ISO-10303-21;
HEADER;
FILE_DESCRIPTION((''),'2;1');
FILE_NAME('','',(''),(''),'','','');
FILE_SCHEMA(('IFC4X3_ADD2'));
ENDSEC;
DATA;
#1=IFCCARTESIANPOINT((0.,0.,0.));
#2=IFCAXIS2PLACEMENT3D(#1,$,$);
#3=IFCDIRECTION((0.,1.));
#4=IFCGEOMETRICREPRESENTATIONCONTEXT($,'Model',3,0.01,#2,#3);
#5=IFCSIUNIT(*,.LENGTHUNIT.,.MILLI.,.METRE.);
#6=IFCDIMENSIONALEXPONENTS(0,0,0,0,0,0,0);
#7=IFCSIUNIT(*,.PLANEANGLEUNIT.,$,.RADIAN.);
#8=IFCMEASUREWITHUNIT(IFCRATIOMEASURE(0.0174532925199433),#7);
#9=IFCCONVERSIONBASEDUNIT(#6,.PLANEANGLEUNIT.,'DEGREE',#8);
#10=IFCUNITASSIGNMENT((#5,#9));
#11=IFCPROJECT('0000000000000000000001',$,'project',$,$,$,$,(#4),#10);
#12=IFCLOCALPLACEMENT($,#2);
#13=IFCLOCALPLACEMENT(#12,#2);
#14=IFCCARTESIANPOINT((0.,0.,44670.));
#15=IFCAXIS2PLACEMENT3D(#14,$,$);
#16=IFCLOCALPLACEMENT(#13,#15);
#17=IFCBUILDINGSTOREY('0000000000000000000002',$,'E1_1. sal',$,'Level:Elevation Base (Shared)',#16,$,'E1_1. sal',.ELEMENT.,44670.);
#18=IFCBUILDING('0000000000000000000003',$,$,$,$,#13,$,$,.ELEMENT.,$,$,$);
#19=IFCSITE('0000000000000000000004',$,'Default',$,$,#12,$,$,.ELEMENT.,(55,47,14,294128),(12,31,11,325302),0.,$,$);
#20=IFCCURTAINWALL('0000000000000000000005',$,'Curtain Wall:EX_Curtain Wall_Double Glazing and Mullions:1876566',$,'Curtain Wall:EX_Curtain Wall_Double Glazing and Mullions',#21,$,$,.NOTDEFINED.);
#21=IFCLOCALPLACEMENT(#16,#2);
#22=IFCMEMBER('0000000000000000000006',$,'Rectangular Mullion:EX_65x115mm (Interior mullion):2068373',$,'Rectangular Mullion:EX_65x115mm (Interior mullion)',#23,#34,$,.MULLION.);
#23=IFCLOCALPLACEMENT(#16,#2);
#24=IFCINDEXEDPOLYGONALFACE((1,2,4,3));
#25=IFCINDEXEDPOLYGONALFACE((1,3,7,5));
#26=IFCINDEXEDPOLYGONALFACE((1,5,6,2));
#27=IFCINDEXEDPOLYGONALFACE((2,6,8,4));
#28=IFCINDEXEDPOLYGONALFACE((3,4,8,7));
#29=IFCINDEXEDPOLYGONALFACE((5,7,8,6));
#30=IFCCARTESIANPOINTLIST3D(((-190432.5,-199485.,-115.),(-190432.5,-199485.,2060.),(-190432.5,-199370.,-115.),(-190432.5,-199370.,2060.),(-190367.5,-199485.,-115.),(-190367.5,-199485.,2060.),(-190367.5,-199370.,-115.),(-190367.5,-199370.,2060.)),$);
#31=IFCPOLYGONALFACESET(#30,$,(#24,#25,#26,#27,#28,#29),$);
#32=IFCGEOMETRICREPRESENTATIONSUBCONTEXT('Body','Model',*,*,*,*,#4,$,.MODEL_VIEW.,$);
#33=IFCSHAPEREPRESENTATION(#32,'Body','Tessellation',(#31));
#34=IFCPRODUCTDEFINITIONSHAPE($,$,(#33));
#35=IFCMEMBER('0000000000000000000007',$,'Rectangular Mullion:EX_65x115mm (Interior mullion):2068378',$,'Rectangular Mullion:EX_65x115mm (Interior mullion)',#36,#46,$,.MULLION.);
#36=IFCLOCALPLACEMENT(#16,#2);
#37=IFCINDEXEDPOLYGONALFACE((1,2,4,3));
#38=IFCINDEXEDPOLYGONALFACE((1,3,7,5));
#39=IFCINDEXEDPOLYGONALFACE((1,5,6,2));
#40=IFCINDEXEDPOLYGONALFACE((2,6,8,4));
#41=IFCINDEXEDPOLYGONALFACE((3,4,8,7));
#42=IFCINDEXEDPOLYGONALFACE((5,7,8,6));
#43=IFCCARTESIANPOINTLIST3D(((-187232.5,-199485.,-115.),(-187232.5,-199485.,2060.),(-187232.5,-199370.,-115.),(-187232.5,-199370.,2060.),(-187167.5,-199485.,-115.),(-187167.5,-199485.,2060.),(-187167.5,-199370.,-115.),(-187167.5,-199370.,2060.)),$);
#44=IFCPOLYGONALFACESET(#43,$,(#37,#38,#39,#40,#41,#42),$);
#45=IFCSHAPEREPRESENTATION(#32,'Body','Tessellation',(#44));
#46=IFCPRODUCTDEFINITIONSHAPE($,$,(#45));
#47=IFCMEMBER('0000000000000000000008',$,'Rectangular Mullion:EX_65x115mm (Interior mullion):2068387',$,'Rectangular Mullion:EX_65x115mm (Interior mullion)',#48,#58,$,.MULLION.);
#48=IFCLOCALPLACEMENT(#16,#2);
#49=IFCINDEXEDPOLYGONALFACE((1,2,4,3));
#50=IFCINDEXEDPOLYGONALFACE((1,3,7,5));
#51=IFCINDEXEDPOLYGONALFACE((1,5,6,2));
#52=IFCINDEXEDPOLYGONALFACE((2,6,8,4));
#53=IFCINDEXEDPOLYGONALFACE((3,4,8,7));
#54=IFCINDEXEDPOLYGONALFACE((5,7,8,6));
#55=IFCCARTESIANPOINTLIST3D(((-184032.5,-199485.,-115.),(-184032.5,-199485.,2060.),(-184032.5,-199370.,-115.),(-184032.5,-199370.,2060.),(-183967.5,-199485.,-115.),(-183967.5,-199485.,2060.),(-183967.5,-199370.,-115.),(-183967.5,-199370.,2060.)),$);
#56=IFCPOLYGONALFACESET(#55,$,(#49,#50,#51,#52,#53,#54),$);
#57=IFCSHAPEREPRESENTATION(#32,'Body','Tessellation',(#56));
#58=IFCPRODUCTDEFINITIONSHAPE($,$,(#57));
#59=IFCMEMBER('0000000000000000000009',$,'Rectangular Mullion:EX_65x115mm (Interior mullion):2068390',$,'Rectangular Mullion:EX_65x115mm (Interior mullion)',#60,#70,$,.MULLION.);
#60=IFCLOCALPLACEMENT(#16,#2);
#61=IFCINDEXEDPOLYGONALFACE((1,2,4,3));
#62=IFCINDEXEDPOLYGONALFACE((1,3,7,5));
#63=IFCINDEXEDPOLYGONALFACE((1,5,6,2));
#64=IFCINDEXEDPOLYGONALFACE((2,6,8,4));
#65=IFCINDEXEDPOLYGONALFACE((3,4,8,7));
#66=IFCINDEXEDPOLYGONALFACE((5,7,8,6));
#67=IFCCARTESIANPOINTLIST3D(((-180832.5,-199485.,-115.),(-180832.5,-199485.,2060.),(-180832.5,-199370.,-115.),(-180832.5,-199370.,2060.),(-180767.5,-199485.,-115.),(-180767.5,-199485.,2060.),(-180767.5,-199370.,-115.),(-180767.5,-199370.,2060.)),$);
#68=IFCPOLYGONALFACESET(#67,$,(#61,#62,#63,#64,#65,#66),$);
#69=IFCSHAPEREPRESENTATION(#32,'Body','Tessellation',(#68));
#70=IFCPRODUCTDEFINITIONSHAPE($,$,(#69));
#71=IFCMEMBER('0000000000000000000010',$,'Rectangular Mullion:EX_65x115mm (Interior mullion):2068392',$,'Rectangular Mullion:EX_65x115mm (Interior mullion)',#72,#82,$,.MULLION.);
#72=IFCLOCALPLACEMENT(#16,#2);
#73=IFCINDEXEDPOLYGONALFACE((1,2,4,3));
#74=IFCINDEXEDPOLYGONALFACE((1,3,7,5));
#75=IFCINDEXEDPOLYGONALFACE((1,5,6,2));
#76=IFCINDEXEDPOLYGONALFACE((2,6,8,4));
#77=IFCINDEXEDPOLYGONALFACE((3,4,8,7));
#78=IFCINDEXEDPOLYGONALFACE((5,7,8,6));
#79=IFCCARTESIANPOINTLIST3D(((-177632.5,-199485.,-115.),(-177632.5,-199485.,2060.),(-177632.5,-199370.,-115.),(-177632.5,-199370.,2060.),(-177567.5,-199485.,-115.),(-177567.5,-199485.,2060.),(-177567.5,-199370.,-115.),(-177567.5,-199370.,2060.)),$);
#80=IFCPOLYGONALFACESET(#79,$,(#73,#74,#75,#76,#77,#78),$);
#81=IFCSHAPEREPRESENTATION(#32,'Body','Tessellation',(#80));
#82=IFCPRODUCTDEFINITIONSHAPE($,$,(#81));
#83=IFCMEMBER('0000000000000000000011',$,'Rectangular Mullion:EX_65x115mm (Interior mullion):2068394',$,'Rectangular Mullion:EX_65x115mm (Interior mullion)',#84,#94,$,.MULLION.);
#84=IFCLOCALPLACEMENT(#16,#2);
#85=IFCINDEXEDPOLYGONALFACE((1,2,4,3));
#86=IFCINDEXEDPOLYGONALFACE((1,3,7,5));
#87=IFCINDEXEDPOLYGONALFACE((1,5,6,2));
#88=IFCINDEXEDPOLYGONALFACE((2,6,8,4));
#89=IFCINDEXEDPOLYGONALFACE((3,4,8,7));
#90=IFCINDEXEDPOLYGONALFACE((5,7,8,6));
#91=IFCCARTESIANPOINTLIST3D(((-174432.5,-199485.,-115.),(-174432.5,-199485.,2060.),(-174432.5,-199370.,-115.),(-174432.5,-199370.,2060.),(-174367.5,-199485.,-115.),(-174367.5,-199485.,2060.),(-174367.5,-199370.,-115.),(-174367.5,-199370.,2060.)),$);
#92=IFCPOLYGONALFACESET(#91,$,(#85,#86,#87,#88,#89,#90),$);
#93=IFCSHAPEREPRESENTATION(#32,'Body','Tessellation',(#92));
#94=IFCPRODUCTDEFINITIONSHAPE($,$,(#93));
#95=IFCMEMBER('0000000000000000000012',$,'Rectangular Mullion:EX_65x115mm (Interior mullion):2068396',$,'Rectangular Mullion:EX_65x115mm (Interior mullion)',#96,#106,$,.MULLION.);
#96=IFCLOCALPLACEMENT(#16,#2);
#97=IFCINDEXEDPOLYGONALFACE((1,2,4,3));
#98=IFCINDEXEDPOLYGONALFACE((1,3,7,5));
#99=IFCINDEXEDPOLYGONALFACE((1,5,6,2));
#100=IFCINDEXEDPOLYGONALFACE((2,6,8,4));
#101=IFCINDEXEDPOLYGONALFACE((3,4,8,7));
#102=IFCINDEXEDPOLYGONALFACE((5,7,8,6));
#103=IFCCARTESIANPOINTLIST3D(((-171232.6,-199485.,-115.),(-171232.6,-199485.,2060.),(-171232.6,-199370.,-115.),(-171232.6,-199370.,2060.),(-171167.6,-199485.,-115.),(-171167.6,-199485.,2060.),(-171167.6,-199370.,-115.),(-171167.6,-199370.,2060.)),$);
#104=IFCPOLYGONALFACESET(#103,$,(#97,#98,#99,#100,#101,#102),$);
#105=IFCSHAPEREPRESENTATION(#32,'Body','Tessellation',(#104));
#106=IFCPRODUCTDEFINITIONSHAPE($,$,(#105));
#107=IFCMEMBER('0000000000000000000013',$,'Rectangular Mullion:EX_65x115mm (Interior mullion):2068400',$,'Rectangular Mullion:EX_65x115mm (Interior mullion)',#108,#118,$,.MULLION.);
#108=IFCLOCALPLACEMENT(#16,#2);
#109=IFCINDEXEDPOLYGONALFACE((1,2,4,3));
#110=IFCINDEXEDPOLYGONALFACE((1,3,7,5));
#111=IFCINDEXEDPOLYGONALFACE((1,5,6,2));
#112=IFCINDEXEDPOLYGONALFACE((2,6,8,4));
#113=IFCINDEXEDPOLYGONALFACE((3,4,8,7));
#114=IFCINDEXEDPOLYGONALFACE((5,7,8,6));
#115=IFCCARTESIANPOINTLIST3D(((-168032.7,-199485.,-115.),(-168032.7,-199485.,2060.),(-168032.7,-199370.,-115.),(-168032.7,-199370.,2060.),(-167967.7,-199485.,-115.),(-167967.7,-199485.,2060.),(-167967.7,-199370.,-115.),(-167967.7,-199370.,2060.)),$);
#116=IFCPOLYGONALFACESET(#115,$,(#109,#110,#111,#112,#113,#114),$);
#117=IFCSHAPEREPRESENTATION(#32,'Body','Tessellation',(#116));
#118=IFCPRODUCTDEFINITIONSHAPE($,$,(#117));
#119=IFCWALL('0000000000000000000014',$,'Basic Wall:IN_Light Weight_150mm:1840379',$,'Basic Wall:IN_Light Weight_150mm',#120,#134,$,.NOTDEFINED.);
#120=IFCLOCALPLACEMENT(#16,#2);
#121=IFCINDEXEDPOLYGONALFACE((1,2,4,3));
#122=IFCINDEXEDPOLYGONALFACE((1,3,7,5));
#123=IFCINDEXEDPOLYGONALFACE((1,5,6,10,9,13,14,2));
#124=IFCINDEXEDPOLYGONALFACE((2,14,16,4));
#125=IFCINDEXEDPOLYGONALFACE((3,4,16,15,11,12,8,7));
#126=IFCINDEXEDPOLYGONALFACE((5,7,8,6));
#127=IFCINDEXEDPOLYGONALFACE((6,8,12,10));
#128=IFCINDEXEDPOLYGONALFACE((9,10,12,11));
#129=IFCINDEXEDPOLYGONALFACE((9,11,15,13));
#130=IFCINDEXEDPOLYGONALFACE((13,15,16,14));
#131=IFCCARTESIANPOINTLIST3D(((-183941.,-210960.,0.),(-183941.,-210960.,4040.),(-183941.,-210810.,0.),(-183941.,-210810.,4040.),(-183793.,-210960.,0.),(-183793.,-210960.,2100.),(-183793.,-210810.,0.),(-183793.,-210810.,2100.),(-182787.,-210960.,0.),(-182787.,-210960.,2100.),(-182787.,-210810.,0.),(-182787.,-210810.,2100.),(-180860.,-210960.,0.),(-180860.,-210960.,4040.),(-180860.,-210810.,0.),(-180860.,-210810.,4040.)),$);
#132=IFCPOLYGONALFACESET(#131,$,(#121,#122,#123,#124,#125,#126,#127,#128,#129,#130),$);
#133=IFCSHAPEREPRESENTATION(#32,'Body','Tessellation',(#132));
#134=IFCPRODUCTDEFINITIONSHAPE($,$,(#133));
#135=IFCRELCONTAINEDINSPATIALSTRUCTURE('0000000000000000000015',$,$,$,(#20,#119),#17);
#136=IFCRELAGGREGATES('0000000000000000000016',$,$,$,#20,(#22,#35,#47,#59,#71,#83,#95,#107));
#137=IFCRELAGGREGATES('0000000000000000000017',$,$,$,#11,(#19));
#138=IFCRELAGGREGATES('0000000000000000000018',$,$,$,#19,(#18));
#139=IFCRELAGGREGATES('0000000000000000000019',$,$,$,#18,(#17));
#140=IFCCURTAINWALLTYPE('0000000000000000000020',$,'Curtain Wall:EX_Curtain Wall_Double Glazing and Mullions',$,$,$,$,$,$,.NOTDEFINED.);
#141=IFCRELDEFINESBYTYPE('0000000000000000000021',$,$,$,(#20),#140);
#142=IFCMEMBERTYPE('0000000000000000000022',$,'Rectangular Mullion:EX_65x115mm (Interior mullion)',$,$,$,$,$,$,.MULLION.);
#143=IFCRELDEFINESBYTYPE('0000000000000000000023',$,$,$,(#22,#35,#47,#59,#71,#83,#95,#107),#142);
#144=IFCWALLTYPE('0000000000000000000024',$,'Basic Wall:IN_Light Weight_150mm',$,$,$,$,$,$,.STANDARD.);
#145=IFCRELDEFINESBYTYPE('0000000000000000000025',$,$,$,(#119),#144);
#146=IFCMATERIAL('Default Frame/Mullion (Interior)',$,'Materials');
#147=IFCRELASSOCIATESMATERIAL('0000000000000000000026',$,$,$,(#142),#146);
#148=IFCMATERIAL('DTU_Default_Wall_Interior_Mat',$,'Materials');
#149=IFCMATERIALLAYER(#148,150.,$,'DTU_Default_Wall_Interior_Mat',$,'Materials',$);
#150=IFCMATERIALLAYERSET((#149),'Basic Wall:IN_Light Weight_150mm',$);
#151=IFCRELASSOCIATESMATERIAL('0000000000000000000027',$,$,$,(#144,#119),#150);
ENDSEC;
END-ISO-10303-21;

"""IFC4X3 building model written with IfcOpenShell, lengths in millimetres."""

from ifc_helpers import new_model, entity, si_unit, converted_unit, direction, frame, frame_2d, origin, origin_2d_with_axis, place, context, subcontext, project, spatial, rectangle, extrude, source, transform, mapped, material, layer, layer_set, material_profile, profile_set, type_object, type_shapes, element, aggregate, save


model = new_model("IFC4X3")

# Units and contexts
model_context = context("Model", 3, precision=0.01, world=origin(), true_north=direction((0.0, 1.0)))
body_context = subcontext(model_context, "Body", "Model", "MODEL_VIEW")
ifc_project = project(units=[si_unit("LENGTHUNIT", "METRE", prefix="MILLI"), converted_unit("PLANEANGLEUNIT", "DEGREE", entity("IfcRatioMeasure", 0.0174532925199433), si_unit("PLANEANGLEUNIT", "RADIAN"), dimensions=[0, 0, 0, 0, 0, 0, 0])], contexts=[model_context])

# Site, building, storey
site_placement = place(None, origin())
site = spatial("IfcSite", under=ifc_project, at=site_placement, Name="Default", CompositionType="ELEMENT", RefLatitude=(55, 47, 14, 294128), RefLongitude=(12, 31, 11, 325302), RefElevation=0.0)
building_placement = place(site_placement, origin())
building = spatial("IfcBuilding", under=site, at=building_placement, CompositionType="ELEMENT")
storey_placement = place(building_placement, frame((0.0, 0.0, 44670.0)))
storey = spatial("IfcBuildingStorey", under=building, at=storey_placement, Name="E1_1. sal", ObjectType="Level:Elevation Base (Shared)", LongName="E1_1. sal", CompositionType="ELEMENT", Elevation=44670.0)

# Curtain wall, members
curtain_wall_type = type_object("IfcCurtainWallType", Name="Curtain Wall:EX_Curtain Wall_Double Glazing and Mullions", PredefinedType="NOTDEFINED")
curtain_wall_1_placement = place(storey_placement, frame((0.0, 0.0, -44670.0)))
curtain_wall_1 = element("IfcCurtainWall", 1, at=curtain_wall_1_placement, inside=storey, type_object=curtain_wall_type, Name="Curtain Wall:EX_Curtain Wall_Double Glazing and Mullions:1876566", ObjectType="Curtain Wall:EX_Curtain Wall_Double Glazing and Mullions", PredefinedType="NOTDEFINED")
ifc_material_1 = material(Name="Default Frame/Mullion (Interior)", Category="Materials")
ifc_material_profile = material_profile(ifc_material_1, rectangle(XDim=115.0, YDim=65.0, at=origin_2d_with_axis()), Name="EX_65x115mm (Interior mullion)")
ifc_profile_set = profile_set([ifc_material_profile], Name="EX_65x115mm (Interior mullion)")
member_type = type_object("IfcMemberType", Name="Rectangular Mullion:EX_65x115mm (Interior mullion)", PredefinedType="MULLION", material=ifc_profile_set)
shared_shape_1 = source(origin(), body_context, "Body", "SweptSolid", [
    extrude(rectangle(XDim=115.0, YDim=65.0, at=origin_2d_with_axis()), frame((0.0, -57.5, -2175.0), z_axis=(0.0, 0.0, 1.0), x_axis=(0.0, -1.0, 0.0)), (0.0, 0.0, 1.0), 2175.0),
])
type_shapes(member_type, [shared_shape_1])
member_1_placement = place(curtain_wall_1_placement, frame((-190400.0, -199485.0, 44555.0), z_axis=(0.0, 0.0, -1.0), x_axis=(1.0, 0.0, 0.0)))
member_1 = element("IfcMember", 2, at=member_1_placement, type_object=member_type, Name="Rectangular Mullion:EX_65x115mm (Interior mullion):2068373", ObjectType="Rectangular Mullion:EX_65x115mm (Interior mullion)", PredefinedType="MULLION", context=body_context, shape_type="MappedRepresentation", body=[
    mapped(shared_shape_1, transform((0.0, 0.0, 0.0), scale=1.0)),
])
member_2_placement = place(curtain_wall_1_placement, frame((-187200.0, -199485.0, 44555.0), z_axis=(0.0, 0.0, -1.0), x_axis=(1.0, 0.0, 0.0)))
member_2 = element("IfcMember", 3, at=member_2_placement, type_object=member_type, Name="Rectangular Mullion:EX_65x115mm (Interior mullion):2068378", ObjectType="Rectangular Mullion:EX_65x115mm (Interior mullion)", PredefinedType="MULLION", context=body_context, shape_type="MappedRepresentation", body=[
    mapped(shared_shape_1, transform((0.0, 0.0, 0.0), scale=1.0)),
])
member_3_placement = place(curtain_wall_1_placement, frame((-184000.0, -199485.0, 44555.0), z_axis=(0.0, 0.0, -1.0), x_axis=(1.0, 0.0, 0.0)))
member_3 = element("IfcMember", 4, at=member_3_placement, type_object=member_type, Name="Rectangular Mullion:EX_65x115mm (Interior mullion):2068387", ObjectType="Rectangular Mullion:EX_65x115mm (Interior mullion)", PredefinedType="MULLION", context=body_context, shape_type="MappedRepresentation", body=[
    mapped(shared_shape_1, transform((0.0, 0.0, 0.0), scale=1.0)),
])
member_4_placement = place(curtain_wall_1_placement, frame((-180800.0, -199485.0, 44555.0), z_axis=(0.0, 0.0, -1.0), x_axis=(1.0, 0.0, 0.0)))
member_4 = element("IfcMember", 5, at=member_4_placement, type_object=member_type, Name="Rectangular Mullion:EX_65x115mm (Interior mullion):2068390", ObjectType="Rectangular Mullion:EX_65x115mm (Interior mullion)", PredefinedType="MULLION", context=body_context, shape_type="MappedRepresentation", body=[
    mapped(shared_shape_1, transform((0.0, 0.0, 0.0), scale=1.0)),
])
member_5_placement = place(curtain_wall_1_placement, frame((-177600.0, -199485.0, 44555.0), z_axis=(0.0, 0.0, -1.0), x_axis=(1.0, 0.0, 0.0)))
member_5 = element("IfcMember", 6, at=member_5_placement, type_object=member_type, Name="Rectangular Mullion:EX_65x115mm (Interior mullion):2068392", ObjectType="Rectangular Mullion:EX_65x115mm (Interior mullion)", PredefinedType="MULLION", context=body_context, shape_type="MappedRepresentation", body=[
    mapped(shared_shape_1, transform((0.0, 0.0, 0.0), scale=1.0)),
])
member_6_placement = place(curtain_wall_1_placement, frame((-174400.0, -199485.0, 44555.0), z_axis=(0.0, 0.0, -1.0), x_axis=(1.0, 0.0, 0.0)))
member_6 = element("IfcMember", 7, at=member_6_placement, type_object=member_type, Name="Rectangular Mullion:EX_65x115mm (Interior mullion):2068394", ObjectType="Rectangular Mullion:EX_65x115mm (Interior mullion)", PredefinedType="MULLION", context=body_context, shape_type="MappedRepresentation", body=[
    mapped(shared_shape_1, transform((0.0, 0.0, 0.0), scale=1.0)),
])
member_7_placement = place(curtain_wall_1_placement, frame((-171200.1, -199485.0, 44555.0), z_axis=(0.0, 0.0, -1.0), x_axis=(1.0, 0.0, 0.0)))
member_7 = element("IfcMember", 8, at=member_7_placement, type_object=member_type, Name="Rectangular Mullion:EX_65x115mm (Interior mullion):2068396", ObjectType="Rectangular Mullion:EX_65x115mm (Interior mullion)", PredefinedType="MULLION", context=body_context, shape_type="MappedRepresentation", body=[
    mapped(shared_shape_1, transform((0.0, 0.0, 0.0), scale=1.0)),
])
member_8_placement = place(curtain_wall_1_placement, frame((-168000.2, -199485.0, 44555.0), z_axis=(0.0, 0.0, -1.0), x_axis=(1.0, 0.0, 0.0)))
member_8 = element("IfcMember", 9, at=member_8_placement, type_object=member_type, Name="Rectangular Mullion:EX_65x115mm (Interior mullion):2068400", ObjectType="Rectangular Mullion:EX_65x115mm (Interior mullion)", PredefinedType="MULLION", context=body_context, shape_type="MappedRepresentation", body=[
    mapped(shared_shape_1, transform((0.0, 0.0, 0.0), scale=1.0)),
])

aggregate(curtain_wall_1, [member_1, member_2, member_3, member_4, member_5, member_6, member_7, member_8])

# Wall, opening
ifc_material_2 = material(Name="DTU_Default_Wall_Interior_Mat", Category="Materials")
ifc_layer_1 = layer(ifc_material_2, 150.0, Name="DTU_Default_Wall_Interior_Mat", Category="Materials")
ifc_layer_set_1 = layer_set([ifc_layer_1], Name="Basic Wall:IN_Light Weight_150mm")
wall_type_1 = type_object("IfcWallType", Name="Basic Wall:IN_Light Weight_150mm", PredefinedType="STANDARD", material=ifc_layer_set_1)
wall_1_placement = place(storey_placement, frame((-183941.0, -210885.0, 0.0)))
wall_1 = element("IfcWall", 10, at=wall_1_placement, inside=storey, type_object=wall_type_1, material=ifc_layer_set_1, Name="Basic Wall:IN_Light Weight_150mm:1840379", ObjectType="Basic Wall:IN_Light Weight_150mm", PredefinedType="NOTDEFINED", context=body_context, shape_type="SweptSolid", body=[
    extrude(rectangle(XDim=3081.0, YDim=150.0, at=frame_2d((1540.5, 0.0), x_axis=(1.0, 0.0))), origin(), (0.0, 0.0, 1.0), 4040.0),
])
opening_1_placement = place(wall_1_placement, frame((1154.0, 75.0, 0.0)))
element("IfcOpeningElement", 11, at=opening_1_placement, cuts=wall_1, PredefinedType="OPENING", context=body_context, shape_type="SweptSolid", body=[
    extrude(rectangle(XDim=2100.0, YDim=1006.0, at=frame_2d((1050.0, 503.0), x_axis=(1.0, 0.0))), frame((0.0, 0.0, 0.0), z_axis=(0.0, -1.0, 0.0), x_axis=(0.0, 0.0, 1.0)), (0.0, 0.0, 1.0), 150.0),
])

save(model, "model.ifc")
